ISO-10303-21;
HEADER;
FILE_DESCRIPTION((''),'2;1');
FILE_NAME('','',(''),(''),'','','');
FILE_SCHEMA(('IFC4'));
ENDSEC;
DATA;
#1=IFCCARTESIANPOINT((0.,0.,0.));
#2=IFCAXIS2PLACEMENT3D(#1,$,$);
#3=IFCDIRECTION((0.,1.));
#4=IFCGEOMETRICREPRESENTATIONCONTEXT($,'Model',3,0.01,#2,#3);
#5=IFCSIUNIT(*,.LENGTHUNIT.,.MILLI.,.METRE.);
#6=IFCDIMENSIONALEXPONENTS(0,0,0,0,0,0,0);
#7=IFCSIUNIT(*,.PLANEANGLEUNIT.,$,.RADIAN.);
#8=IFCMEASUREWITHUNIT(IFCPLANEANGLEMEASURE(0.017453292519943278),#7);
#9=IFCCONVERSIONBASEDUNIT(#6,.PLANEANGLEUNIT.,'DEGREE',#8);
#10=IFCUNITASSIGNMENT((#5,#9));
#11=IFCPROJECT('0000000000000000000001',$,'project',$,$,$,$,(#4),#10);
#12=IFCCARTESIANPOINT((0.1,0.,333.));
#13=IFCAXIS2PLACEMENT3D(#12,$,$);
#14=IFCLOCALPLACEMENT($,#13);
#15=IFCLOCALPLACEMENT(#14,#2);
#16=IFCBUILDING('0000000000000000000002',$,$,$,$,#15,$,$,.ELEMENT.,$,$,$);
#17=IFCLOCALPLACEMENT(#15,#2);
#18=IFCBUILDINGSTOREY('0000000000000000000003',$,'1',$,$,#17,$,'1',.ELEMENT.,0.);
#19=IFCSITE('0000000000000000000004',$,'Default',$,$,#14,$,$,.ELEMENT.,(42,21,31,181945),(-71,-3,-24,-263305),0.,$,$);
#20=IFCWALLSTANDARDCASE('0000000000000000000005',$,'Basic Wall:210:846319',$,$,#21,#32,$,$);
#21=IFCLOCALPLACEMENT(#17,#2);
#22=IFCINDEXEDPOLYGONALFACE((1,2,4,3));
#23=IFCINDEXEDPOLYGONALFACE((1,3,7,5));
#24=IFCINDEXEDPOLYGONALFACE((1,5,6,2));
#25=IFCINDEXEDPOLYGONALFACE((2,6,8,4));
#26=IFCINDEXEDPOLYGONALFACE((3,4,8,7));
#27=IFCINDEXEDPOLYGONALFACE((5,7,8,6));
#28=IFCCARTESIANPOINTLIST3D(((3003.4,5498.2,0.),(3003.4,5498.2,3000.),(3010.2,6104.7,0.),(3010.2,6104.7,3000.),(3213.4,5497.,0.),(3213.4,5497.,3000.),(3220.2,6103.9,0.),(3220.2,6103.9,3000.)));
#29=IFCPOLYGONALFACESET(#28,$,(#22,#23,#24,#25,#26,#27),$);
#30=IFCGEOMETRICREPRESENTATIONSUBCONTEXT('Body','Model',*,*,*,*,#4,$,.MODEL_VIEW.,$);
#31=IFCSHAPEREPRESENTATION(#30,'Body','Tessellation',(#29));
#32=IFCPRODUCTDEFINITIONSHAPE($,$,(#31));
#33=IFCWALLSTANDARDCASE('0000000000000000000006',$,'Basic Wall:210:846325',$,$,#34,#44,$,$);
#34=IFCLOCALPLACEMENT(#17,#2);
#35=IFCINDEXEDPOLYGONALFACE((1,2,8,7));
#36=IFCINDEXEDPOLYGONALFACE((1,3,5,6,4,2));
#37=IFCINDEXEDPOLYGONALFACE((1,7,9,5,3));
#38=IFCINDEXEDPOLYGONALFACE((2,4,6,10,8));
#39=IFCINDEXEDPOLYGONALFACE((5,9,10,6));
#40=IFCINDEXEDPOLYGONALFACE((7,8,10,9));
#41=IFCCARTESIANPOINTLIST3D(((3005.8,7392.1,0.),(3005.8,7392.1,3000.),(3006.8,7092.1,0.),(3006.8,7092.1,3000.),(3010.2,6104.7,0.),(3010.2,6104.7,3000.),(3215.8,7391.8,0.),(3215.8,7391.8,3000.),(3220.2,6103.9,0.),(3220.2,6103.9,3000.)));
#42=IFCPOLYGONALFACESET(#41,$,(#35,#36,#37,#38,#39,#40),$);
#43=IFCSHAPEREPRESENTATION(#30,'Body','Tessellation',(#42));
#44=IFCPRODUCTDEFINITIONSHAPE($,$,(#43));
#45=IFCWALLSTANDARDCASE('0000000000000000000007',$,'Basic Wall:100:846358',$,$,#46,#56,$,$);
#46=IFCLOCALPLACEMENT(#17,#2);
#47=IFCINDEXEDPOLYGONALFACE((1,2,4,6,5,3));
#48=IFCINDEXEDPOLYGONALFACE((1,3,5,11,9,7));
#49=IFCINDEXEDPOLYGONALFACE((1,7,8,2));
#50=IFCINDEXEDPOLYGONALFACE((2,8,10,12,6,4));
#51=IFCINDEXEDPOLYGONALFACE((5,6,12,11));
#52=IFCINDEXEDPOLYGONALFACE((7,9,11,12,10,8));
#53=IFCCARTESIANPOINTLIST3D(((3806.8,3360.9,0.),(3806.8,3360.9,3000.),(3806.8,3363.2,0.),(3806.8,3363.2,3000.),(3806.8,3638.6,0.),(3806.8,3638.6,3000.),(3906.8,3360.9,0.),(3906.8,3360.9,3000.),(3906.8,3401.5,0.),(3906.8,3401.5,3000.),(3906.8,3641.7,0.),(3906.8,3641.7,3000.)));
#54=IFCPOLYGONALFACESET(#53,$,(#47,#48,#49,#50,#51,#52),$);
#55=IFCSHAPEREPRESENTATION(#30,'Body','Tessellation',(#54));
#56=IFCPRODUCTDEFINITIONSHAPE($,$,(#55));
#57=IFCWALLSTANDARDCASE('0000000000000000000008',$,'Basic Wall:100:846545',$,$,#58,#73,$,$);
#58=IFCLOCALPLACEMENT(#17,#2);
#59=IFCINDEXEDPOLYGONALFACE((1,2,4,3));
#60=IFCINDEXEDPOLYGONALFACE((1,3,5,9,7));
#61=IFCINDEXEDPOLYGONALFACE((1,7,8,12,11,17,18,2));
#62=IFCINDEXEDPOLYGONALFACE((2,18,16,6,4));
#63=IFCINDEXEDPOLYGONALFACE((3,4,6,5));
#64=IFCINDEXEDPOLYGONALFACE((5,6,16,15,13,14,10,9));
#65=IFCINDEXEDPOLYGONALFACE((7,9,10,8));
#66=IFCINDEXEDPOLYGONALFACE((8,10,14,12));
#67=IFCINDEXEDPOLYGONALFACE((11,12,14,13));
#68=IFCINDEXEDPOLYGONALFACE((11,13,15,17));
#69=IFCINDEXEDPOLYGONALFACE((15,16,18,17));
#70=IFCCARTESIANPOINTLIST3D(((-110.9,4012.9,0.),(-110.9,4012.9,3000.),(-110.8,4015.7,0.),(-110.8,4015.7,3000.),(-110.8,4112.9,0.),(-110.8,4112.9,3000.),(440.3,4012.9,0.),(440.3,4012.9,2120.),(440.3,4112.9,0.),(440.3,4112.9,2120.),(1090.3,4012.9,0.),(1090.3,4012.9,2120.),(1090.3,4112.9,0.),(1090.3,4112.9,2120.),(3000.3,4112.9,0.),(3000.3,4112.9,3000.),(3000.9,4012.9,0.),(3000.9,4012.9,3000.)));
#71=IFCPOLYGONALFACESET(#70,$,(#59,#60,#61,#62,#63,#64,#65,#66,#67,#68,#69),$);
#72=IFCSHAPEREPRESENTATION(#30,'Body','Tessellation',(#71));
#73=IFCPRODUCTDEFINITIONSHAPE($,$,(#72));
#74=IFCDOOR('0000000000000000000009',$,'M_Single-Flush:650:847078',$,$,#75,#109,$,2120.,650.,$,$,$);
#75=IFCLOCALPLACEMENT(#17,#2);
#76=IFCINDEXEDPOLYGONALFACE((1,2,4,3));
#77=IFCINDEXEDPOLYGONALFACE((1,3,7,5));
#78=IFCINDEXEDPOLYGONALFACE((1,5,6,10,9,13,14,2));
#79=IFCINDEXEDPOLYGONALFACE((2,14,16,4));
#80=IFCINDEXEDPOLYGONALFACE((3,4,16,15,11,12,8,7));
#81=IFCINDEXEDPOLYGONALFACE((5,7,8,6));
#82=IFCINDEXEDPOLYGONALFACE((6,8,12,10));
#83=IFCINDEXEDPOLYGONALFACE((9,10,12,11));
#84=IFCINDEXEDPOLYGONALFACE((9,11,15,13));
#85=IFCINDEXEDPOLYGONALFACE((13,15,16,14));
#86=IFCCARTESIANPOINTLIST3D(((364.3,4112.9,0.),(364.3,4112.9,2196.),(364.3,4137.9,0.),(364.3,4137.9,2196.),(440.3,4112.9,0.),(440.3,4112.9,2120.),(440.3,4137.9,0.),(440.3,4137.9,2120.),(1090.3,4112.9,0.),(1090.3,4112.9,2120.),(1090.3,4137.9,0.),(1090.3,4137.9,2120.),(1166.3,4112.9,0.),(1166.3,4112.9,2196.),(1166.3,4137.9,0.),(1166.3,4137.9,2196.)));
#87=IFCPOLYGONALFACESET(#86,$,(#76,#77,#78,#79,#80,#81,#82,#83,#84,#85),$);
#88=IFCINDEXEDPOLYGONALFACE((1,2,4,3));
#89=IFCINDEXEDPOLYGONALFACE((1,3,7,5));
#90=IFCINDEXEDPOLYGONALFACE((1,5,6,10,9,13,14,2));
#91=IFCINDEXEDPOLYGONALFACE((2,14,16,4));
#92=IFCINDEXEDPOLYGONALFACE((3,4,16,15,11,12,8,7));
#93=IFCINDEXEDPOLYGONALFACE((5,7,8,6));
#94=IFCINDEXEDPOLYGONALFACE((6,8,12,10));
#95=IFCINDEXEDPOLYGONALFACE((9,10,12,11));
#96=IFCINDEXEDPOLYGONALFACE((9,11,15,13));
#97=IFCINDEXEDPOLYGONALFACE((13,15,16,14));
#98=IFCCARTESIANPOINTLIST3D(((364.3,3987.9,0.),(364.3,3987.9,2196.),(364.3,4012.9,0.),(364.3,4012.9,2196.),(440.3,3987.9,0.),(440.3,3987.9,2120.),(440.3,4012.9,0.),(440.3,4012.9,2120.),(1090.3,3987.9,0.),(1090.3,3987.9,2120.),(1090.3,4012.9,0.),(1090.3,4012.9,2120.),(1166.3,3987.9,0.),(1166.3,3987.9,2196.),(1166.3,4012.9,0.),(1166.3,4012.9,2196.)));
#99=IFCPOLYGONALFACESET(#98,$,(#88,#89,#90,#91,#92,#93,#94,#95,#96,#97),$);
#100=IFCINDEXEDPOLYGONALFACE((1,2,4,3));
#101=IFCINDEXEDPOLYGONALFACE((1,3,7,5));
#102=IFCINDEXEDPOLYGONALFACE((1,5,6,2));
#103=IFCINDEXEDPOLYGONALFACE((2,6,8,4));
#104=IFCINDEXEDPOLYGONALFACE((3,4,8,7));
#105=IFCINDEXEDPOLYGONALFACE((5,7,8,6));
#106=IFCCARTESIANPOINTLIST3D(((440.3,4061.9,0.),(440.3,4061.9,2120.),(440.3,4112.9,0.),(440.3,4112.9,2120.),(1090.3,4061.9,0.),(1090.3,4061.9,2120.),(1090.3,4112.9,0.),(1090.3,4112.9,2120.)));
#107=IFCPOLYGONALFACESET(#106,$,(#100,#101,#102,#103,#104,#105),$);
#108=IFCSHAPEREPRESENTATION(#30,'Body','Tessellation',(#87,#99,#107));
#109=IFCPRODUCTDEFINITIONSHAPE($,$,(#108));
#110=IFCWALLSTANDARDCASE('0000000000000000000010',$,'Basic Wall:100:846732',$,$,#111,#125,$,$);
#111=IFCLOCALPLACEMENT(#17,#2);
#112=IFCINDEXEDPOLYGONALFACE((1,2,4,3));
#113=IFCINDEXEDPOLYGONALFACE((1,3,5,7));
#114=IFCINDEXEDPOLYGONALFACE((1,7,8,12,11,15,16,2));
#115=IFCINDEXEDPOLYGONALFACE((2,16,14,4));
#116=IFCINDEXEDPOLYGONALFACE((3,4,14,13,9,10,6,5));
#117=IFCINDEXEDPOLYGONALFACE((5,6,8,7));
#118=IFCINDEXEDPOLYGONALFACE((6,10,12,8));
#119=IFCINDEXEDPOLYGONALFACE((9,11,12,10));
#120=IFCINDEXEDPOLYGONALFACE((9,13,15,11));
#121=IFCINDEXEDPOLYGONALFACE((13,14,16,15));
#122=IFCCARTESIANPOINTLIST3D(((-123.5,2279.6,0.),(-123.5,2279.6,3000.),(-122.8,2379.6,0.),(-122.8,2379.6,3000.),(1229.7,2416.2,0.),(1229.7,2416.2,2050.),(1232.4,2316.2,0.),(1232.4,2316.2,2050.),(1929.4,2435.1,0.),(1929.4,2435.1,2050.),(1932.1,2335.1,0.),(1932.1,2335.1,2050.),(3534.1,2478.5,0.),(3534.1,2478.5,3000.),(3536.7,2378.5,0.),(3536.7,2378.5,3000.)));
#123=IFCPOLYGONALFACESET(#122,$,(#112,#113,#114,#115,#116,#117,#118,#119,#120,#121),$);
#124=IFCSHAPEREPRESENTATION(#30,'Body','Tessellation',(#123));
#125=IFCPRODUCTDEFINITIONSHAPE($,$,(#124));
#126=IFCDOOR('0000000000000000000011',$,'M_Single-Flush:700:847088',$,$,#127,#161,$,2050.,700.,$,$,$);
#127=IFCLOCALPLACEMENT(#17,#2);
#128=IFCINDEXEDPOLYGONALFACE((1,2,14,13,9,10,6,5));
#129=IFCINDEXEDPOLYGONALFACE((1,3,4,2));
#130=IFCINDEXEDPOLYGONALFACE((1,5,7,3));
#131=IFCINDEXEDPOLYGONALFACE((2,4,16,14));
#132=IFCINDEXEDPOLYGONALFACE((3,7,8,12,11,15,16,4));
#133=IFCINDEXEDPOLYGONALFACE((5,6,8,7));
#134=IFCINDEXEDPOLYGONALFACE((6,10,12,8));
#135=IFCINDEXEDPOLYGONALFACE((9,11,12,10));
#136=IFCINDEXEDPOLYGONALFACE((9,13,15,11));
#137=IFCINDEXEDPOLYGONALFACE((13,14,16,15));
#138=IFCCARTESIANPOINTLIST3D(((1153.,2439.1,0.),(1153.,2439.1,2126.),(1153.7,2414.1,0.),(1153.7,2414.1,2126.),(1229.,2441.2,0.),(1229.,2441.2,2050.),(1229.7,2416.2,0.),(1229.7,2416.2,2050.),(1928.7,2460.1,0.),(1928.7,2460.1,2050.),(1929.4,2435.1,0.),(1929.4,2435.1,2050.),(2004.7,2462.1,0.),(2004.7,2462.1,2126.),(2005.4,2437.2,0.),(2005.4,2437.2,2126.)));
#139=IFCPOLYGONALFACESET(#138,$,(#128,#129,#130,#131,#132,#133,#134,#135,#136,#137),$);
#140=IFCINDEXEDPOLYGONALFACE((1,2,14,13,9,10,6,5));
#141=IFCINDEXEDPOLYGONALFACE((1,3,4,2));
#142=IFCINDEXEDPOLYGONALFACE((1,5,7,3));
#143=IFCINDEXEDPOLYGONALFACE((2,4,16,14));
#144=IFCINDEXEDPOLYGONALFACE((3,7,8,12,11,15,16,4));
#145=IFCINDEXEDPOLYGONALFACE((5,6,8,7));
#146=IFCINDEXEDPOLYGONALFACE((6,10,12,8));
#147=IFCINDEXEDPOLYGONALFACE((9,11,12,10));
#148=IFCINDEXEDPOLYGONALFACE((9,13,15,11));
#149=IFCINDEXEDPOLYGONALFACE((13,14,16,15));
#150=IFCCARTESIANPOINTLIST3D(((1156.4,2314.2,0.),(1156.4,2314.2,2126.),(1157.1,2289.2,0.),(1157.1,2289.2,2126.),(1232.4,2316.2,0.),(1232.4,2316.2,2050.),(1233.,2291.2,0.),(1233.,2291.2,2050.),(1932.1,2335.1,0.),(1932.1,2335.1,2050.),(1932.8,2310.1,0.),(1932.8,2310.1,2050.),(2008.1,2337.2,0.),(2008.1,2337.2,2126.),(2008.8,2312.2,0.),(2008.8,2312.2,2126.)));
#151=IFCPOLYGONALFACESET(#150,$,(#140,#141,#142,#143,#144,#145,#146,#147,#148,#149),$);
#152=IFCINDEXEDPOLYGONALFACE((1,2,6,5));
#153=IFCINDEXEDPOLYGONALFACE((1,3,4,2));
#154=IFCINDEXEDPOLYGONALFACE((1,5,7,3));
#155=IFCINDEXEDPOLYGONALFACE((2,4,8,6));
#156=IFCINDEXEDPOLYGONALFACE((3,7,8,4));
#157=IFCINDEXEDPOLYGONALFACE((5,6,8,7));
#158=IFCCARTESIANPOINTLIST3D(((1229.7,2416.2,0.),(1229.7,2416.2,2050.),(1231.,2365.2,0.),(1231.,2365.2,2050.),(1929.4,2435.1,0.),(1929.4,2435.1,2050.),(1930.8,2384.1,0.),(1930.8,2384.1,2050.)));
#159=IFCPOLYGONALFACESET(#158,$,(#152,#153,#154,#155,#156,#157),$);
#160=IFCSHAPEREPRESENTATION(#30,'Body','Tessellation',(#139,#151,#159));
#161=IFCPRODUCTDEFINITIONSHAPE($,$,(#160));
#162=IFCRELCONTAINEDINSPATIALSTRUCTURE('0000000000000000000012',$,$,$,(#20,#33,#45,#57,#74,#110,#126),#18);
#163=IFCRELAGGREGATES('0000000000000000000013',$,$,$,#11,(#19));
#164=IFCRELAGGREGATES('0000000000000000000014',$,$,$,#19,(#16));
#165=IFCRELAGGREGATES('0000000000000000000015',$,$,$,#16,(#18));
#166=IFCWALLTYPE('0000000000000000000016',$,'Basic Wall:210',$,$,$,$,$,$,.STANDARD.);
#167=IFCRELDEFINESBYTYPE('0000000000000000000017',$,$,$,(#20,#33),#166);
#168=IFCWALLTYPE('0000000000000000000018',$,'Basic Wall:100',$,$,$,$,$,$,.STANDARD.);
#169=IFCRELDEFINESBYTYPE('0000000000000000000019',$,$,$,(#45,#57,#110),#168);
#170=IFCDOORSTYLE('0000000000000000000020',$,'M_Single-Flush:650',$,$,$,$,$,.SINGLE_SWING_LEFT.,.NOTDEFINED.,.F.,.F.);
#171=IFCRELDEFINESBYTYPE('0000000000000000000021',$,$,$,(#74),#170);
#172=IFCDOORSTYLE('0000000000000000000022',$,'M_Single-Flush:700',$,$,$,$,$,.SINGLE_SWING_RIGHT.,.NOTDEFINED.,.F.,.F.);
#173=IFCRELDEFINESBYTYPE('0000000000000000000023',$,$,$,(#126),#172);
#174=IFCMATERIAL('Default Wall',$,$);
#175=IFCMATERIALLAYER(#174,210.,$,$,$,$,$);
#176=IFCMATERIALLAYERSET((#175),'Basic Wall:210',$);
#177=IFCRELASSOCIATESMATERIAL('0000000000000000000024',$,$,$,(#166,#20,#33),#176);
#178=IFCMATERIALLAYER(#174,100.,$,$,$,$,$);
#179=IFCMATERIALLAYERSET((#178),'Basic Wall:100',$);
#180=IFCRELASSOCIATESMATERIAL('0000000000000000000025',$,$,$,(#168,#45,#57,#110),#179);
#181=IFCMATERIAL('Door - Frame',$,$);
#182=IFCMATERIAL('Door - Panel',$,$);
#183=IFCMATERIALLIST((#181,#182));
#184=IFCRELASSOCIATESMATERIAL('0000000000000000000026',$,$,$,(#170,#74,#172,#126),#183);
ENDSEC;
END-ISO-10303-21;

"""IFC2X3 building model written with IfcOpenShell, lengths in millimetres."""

from ifc_helpers import new_model, entity, si_unit, converted_unit, direction, frame, frame_2d, origin, origin_2d_with_axis, place, context, subcontext, project, spatial, polyline, rectangle, outline, extrude, source, transform, mapped, material, material_list, layer, layer_set, layer_usage, type_object, type_shapes, element, fill, save


model = new_model("IFC2X3")

# Units and contexts
model_context = context("Model", 3, precision=0.01, world=origin(), true_north=direction((0.0, 1.0)))
body_context = subcontext(model_context, "Body", "Model", "MODEL_VIEW")
ifc_project = project(units=[si_unit("LENGTHUNIT", "METRE", prefix="MILLI"), converted_unit("PLANEANGLEUNIT", "DEGREE", entity("IfcPlaneAngleMeasure", 0.017453292519943278), si_unit("PLANEANGLEUNIT", "RADIAN"), dimensions=[0, 0, 0, 0, 0, 0, 0])], contexts=[model_context])

# Site, building, storey
site_placement = place(None, frame((0.1, 0.0, 333.0)))
site = spatial("IfcSite", under=ifc_project, at=site_placement, Name="Default", CompositionType="ELEMENT", RefLatitude=(42, 21, 31, 181945), RefLongitude=(-71, -3, -24, -263305), RefElevation=0.0)
building_placement = place(site_placement, origin())
building = spatial("IfcBuilding", under=site, at=building_placement, CompositionType="ELEMENT")
storey_placement = place(building_placement, origin())
storey = spatial("IfcBuildingStorey", under=building, at=storey_placement, Name="1", LongName="1", CompositionType="ELEMENT", Elevation=0.0)

# Shared definitions
ifc_material_1 = material(Name="Default Wall")

# Walls
ifc_layer_1 = layer(ifc_material_1, 210.0)
ifc_layer_set_1 = layer_set([ifc_layer_1], Name="Basic Wall:210")
wall_type_1 = type_object("IfcWallType", Name="Basic Wall:210", PredefinedType="STANDARD", material=ifc_layer_set_1)
ifc_layer_usage_1 = layer_usage(ifc_layer_set_1, "AXIS2", "NEGATIVE", 105.0)
wall_1_placement = place(storey_placement, frame((3115.2, 6105.1, 0.0), z_axis=(0.0, 0.0, 1.0), x_axis=(-0.011193, -0.999937, 0.0)))
element("IfcWallStandardCase", 1, at=wall_1_placement, inside=storey, type_object=wall_type_1, material=ifc_layer_usage_1, Name="Basic Wall:210:846319", context=body_context, shape_type="SweptSolid", body=[
    extrude(outline(polyline([(608.1, -105.0), (606.9, 105.0), (0.0, 105.0), (1.5, -105.0), (608.1, -105.0)])), origin(), (0.0, 0.0, 1.0), 3000.0),
])
ifc_layer_usage_2 = layer_usage(ifc_layer_set_1, "AXIS2", "NEGATIVE", 105.0)
wall_2_placement = place(storey_placement, frame((3110.8, 7392.5, 0.0), z_axis=(0.0, 0.0, 1.0), x_axis=(0.003397, -0.999994, 0.0)))
element("IfcWallStandardCase", 2, at=wall_2_placement, inside=storey, type_object=wall_type_1, material=ifc_layer_usage_2, Name="Basic Wall:210:846325", context=body_context, shape_type="SweptSolid", body=[
    extrude(outline(polyline([(1287.4, -105.0), (1288.9, 105.0), (1.0, 105.0), (0.0, -105.0), (300.0, -105.0), (1287.4, -105.0)])), origin(), (0.0, 0.0, 1.0), 3000.0),
])
ifc_layer_2 = layer(ifc_material_1, 100.0)
ifc_layer_set_2 = layer_set([ifc_layer_2], Name="Basic Wall:100")
ifc_layer_usage_3 = layer_usage(ifc_layer_set_2, "AXIS2", "NEGATIVE", 50.0)
wall_type_2 = type_object("IfcWallType", Name="Basic Wall:100", PredefinedType="STANDARD", material=ifc_layer_set_2)
wall_3_placement = place(storey_placement, frame((3856.8, 3360.9, 0.0), z_axis=(0.0, 0.0, 1.0), x_axis=(0.0, 1.0, 0.0)))
element("IfcWallStandardCase", 3, at=wall_3_placement, inside=storey, type_object=wall_type_2, material=ifc_layer_usage_3, Name="Basic Wall:100:846358", context=body_context, shape_type="SweptSolid", body=[
    extrude(outline(polyline([(280.7, -50.0), (277.6, 50.0), (2.3, 50.0), (0.0, 50.0), (0.0, -50.0), (40.6, -50.0), (280.7, -50.0)])), origin(), (0.0, 0.0, 1.0), 3000.0),
])

# Walls, openings, doors
ifc_layer_usage_4 = layer_usage(ifc_layer_set_2, "AXIS2", "NEGATIVE", 50.0)
wall_4_placement = place(storey_placement, frame((3000.9, 4062.9, 0.0), z_axis=(0.0, 0.0, 1.0), x_axis=(-1.0, 0.0, 0.0)))
wall_4 = element("IfcWallStandardCase", 4, at=wall_4_placement, inside=storey, type_object=wall_type_2, material=ifc_layer_usage_4, Name="Basic Wall:100:846545", context=body_context, shape_type="SweptSolid", body=[
    extrude(outline(polyline([(0.6, -50.0), (3111.7, -50.0), (3111.7, 47.1), (3111.8, 50.0), (0.0, 50.0), (0.6, -50.0)])), origin(), (0.0, 0.0, 1.0), 3000.0),
])
opening_1_placement = place(wall_4_placement, frame((2560.6, 50.0, 0.0)))
opening_1 = element("IfcOpeningElement", 5, at=opening_1_placement, cuts=wall_4, ObjectType="Opening", context=body_context, shape_type="SweptSolid", body=[
    extrude(rectangle(XDim=650.0, YDim=2120.0, at=frame_2d((1060.0, 325.0), x_axis=(0.0, -1.0))), frame((0.0, 0.0, 0.0), z_axis=(0.0, -1.0, 0.0), x_axis=(0.0, 0.0, 1.0)), (0.0, 0.0, 1.0), 100.0),
])
ifc_material_2 = material(Name="Door - Frame")
ifc_material_3 = material(Name="Door - Panel")
ifc_material_list_1 = material_list([ifc_material_2, ifc_material_3])
door_style_1 = type_object("IfcDoorStyle", Name="M_Single-Flush:650", ConstructionType="NOTDEFINED", OperationType="SINGLE_SWING_LEFT", ParameterTakesPrecedence=False, Sizeable=False, material=ifc_material_list_1)
shared_shape_1 = source(origin(), body_context, "Body", "SweptSolid", [
    extrude(outline(polyline([(-401.0, -1117.0), (401.0, -1117.0), (401.0, 1079.0), (325.0, 1079.0), (325.0, -1041.0), (-325.0, -1041.0), (-325.0, 1079.0), (-401.0, 1079.0), (-401.0, -1117.0)])), frame((325.0, 125.0, 1079.0), z_axis=(0.0, -1.0, 0.0), x_axis=(-1.0, 0.0, 0.0)), (0.0, 0.0, 1.0), 25.0),
    extrude(outline(polyline([(-1117.0, -401.0), (1079.0, -401.0), (1079.0, -325.0), (-1041.0, -325.0), (-1041.0, 325.0), (1079.0, 325.0), (1079.0, 401.0), (-1117.0, 401.0), (-1117.0, -401.0)])), frame((325.0, 0.0, 1079.0), z_axis=(0.0, -1.0, 0.0), x_axis=(0.0, 0.0, -1.0)), (0.0, 0.0, 1.0), 25.0),
    extrude(rectangle(XDim=650.0, YDim=51.0, at=origin_2d_with_axis()), frame((325.0, 74.5, 0.0)), (0.0, 0.0, 1.0), 2120.0),
])
type_shapes(door_style_1, [shared_shape_1])
door_1_placement = place(opening_1_placement, frame((0.0, 0.0, 0.0), z_axis=(0.0, 0.0, 1.0), x_axis=(-1.0, 0.0, 0.0)))
door_1 = element("IfcDoor", 6, at=door_1_placement, inside=storey, type_object=door_style_1, material=ifc_material_list_1, Name="M_Single-Flush:650:847078", OverallHeight=2120.0, OverallWidth=650.0, context=body_context, shape_type="MappedRepresentation", body=[
    mapped(shared_shape_1, transform((0.0, 0.0, 0.0), scale=1.0)),
])
fill(opening_1, door_1)
ifc_layer_usage_5 = layer_usage(ifc_layer_set_2, "AXIS2", "NEGATIVE", 50.0)
wall_5_placement = place(storey_placement, frame((-124.9, 2329.5, 0.0), z_axis=(0.0, 0.0, 1.0), x_axis=(0.999635, 0.027022, 0.0)))
wall_5 = element("IfcWallStandardCase", 7, at=wall_5_placement, inside=storey, type_object=wall_type_2, material=ifc_layer_usage_5, Name="Basic Wall:100:846732", context=body_context, shape_type="SweptSolid", body=[
    extrude(outline(polyline([(0.0, -50.0), (3661.5, -50.0), (3661.7, 50.0), (3230.6, 50.0), (3130.5, 50.0), (3.4, 50.0), (0.0, -50.0)])), origin(), (0.0, 0.0, 1.0), 3000.0),
])
opening_2_placement = place(wall_5_placement, frame((1356.4, -50.0, 0.0)))
opening_2 = element("IfcOpeningElement", 8, at=opening_2_placement, cuts=wall_5, ObjectType="Opening", context=body_context, shape_type="SweptSolid", body=[
    extrude(rectangle(XDim=700.0, YDim=2050.0, at=frame_2d((1025.0, 350.0), x_axis=(0.0, 1.0))), frame((0.0, 0.0, 0.0), z_axis=(0.0, 1.0, 0.0), x_axis=(0.0, 0.0, 1.0)), (0.0, 0.0, 1.0), 100.0),
])
door_style_2 = type_object("IfcDoorStyle", Name="M_Single-Flush:700", ConstructionType="NOTDEFINED", OperationType="SINGLE_SWING_RIGHT", ParameterTakesPrecedence=False, Sizeable=False, material=ifc_material_list_1)
shared_shape_2 = source(origin(), body_context, "Body", "SweptSolid", [
    extrude(outline(polyline([(-426.0, -1082.0), (426.0, -1082.0), (426.0, 1044.0), (350.0, 1044.0), (350.0, -1006.0), (-350.0, -1006.0), (-350.0, 1044.0), (-426.0, 1044.0), (-426.0, -1082.0)])), frame((350.0, 100.0, 1044.0), z_axis=(0.0, 1.0, 0.0), x_axis=(1.0, 0.0, 0.0)), (0.0, 0.0, 1.0), 25.0),
    extrude(outline(polyline([(-1082.0, -426.0), (1044.0, -426.0), (1044.0, -350.0), (-1006.0, -350.0), (-1006.0, 350.0), (1044.0, 350.0), (1044.0, 426.0), (-1082.0, 426.0), (-1082.0, -426.0)])), frame((350.0, -25.0, 1044.0), z_axis=(0.0, 1.0, 0.0), x_axis=(0.0, 0.0, -1.0)), (0.0, 0.0, 1.0), 25.0),
    extrude(rectangle(XDim=51.0, YDim=700.0, at=origin_2d_with_axis()), frame((350.0, 74.5, 0.0), z_axis=(0.0, 0.0, 1.0), x_axis=(0.0, 1.0, 0.0)), (0.0, 0.0, 1.0), 2050.0),
])
type_shapes(door_style_2, [shared_shape_2])
door_2_placement = place(opening_2_placement, origin())
door_2 = element("IfcDoor", 9, at=door_2_placement, inside=storey, type_object=door_style_2, material=ifc_material_list_1, Name="M_Single-Flush:700:847088", OverallHeight=2050.0, OverallWidth=700.0, context=body_context, shape_type="MappedRepresentation", body=[
    mapped(shared_shape_2, transform((0.0, 0.0, 0.0), scale=1.0)),
])
fill(opening_2, door_2)

save(model, "model.ifc")
